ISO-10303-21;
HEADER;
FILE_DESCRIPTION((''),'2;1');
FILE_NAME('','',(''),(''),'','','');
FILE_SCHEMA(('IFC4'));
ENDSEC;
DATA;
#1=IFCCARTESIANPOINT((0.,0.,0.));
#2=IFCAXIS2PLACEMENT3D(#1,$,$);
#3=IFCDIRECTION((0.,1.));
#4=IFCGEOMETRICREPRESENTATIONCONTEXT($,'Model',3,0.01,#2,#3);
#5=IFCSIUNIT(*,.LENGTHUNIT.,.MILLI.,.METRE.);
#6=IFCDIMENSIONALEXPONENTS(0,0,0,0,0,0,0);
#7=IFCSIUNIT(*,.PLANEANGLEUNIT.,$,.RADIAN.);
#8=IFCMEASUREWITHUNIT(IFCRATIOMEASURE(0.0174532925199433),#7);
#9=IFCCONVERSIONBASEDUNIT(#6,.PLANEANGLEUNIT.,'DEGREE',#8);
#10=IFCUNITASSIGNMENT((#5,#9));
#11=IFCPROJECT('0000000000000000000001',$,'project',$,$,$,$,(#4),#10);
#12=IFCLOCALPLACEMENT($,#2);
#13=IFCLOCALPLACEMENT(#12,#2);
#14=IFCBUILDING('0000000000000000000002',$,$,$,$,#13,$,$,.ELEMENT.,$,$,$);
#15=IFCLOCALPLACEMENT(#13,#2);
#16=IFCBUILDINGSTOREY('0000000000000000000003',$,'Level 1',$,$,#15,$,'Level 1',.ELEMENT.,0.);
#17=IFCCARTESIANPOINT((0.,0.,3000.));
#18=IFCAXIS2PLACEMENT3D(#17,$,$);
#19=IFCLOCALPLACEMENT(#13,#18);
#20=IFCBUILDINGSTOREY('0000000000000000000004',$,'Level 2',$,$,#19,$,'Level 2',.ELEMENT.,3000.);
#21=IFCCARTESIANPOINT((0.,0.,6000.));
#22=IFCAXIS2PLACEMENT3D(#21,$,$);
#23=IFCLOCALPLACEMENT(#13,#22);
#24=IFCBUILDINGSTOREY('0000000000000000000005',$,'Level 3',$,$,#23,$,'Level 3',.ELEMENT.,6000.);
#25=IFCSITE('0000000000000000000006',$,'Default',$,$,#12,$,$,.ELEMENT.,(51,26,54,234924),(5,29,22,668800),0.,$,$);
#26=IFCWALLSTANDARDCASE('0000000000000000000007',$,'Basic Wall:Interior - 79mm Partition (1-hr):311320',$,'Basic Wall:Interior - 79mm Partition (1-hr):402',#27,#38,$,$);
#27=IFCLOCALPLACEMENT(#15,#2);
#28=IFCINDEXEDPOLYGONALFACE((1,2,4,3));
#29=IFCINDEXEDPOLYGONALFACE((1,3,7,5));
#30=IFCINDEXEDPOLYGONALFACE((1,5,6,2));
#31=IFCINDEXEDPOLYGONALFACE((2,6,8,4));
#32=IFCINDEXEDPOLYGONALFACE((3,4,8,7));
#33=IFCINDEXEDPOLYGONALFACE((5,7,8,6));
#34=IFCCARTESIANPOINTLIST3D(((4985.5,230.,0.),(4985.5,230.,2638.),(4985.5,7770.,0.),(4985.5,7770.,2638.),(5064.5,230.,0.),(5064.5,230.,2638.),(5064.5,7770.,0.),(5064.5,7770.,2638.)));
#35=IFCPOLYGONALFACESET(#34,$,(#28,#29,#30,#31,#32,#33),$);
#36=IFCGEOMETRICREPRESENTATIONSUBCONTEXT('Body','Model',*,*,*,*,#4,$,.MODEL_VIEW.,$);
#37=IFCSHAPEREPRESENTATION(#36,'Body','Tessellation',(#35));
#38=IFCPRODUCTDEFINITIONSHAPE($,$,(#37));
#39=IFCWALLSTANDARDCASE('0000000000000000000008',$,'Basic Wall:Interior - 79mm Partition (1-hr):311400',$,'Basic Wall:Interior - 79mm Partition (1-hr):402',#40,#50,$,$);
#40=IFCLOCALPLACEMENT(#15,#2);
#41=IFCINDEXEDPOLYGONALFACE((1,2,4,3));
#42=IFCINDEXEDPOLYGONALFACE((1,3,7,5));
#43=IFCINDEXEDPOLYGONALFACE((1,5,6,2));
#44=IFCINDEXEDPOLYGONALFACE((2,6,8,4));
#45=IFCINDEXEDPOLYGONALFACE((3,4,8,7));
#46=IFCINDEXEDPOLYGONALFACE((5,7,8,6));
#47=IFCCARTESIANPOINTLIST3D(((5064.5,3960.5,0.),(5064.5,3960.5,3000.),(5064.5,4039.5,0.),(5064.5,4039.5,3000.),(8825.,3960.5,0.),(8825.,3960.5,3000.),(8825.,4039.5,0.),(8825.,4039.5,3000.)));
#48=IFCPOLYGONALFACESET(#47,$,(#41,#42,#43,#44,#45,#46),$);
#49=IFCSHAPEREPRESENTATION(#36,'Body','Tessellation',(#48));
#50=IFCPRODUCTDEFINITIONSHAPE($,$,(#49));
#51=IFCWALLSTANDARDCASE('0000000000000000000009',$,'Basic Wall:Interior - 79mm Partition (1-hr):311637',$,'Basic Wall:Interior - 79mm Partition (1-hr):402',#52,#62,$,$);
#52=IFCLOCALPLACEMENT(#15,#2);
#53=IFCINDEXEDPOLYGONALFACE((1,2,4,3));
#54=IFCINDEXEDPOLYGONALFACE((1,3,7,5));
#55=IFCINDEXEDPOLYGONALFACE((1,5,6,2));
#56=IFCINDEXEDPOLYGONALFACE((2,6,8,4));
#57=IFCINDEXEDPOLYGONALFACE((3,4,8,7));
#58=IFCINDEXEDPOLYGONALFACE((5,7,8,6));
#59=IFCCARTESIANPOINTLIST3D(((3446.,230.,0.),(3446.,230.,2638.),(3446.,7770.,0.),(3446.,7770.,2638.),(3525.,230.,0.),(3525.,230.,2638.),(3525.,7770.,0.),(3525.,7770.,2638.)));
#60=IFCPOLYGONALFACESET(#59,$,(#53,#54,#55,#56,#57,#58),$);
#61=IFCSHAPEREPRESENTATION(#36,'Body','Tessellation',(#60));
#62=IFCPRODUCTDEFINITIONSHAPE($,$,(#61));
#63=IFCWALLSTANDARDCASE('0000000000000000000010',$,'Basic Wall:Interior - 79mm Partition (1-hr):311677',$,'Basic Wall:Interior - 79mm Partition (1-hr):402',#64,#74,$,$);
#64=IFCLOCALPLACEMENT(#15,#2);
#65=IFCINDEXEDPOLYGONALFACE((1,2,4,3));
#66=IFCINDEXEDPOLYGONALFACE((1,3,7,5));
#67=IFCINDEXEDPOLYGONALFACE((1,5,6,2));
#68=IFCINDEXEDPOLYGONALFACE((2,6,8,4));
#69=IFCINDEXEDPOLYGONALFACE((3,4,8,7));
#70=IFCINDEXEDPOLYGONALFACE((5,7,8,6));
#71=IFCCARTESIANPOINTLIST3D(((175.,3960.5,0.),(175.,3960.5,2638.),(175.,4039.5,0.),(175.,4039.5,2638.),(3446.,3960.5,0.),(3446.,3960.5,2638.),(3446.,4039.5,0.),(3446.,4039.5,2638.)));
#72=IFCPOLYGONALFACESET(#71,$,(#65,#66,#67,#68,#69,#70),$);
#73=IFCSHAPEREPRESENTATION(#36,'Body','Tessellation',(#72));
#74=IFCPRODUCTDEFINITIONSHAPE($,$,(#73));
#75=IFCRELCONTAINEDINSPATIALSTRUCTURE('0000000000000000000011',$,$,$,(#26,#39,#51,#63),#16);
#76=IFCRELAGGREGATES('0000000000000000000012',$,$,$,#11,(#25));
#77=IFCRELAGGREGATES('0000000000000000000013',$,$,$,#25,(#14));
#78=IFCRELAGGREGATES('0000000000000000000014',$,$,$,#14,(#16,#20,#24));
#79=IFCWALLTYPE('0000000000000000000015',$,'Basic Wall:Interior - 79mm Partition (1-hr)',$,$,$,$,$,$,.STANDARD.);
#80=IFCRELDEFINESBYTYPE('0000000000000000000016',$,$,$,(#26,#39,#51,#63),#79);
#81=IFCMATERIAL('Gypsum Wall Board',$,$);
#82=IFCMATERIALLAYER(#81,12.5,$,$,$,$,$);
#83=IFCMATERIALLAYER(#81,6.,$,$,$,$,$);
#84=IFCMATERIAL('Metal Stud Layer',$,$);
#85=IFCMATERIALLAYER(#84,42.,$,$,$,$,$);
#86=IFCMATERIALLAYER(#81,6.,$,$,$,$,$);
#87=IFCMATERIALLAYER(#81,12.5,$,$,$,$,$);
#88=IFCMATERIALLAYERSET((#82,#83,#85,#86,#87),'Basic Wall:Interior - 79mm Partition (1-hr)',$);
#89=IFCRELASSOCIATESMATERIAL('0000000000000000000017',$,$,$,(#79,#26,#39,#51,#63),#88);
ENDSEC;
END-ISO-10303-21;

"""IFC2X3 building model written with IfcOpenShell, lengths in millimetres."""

from ifc_helpers import new_model, entity, si_unit, converted_unit, direction, frame, frame_2d, origin, place, context, subcontext, project, spatial, polyline, rectangle, extrude, clip, bounded_halfspace, material, layer, layer_set, layer_usage, type_object, element, save


model = new_model("IFC2X3")

# Units and contexts
model_context = context("Model", 3, precision=0.01, world=origin(), true_north=direction((0.0, 1.0)))
body_context = subcontext(model_context, "Body", "Model", "MODEL_VIEW")
ifc_project = project(units=[si_unit("LENGTHUNIT", "METRE", prefix="MILLI"), converted_unit("PLANEANGLEUNIT", "DEGREE", entity("IfcRatioMeasure", 0.0174532925199433), si_unit("PLANEANGLEUNIT", "RADIAN"), dimensions=[0, 0, 0, 0, 0, 0, 0])], contexts=[model_context])

# Site, building, storey
site_placement = place(None, origin())
site = spatial("IfcSite", under=ifc_project, at=site_placement, Name="Default", CompositionType="ELEMENT", RefLatitude=(51, 26, 54, 234924), RefLongitude=(5, 29, 22, 668800), RefElevation=0.0)
building_placement = place(site_placement, origin())
building = spatial("IfcBuilding", under=site, at=building_placement, CompositionType="ELEMENT")
storey_1_placement = place(building_placement, origin())
storey_1 = spatial("IfcBuildingStorey", under=building, at=storey_1_placement, Name="Level 1", LongName="Level 1", CompositionType="ELEMENT", Elevation=0.0)

# Shared definitions
ifc_material_1 = material(Name="Metal Stud Layer")
ifc_material_2 = material(Name="Gypsum Wall Board")

# Shared definitions
storey_2_placement = place(building_placement, frame((0.0, 0.0, 3000.0)))
storey_2 = spatial("IfcBuildingStorey", under=building, at=storey_2_placement, Name="Level 2", LongName="Level 2", CompositionType="ELEMENT", Elevation=3000.0)

# Shared definitions
storey_3_placement = place(building_placement, frame((0.0, 0.0, 6000.0)))
storey_3 = spatial("IfcBuildingStorey", under=building, at=storey_3_placement, Name="Level 3", LongName="Level 3", CompositionType="ELEMENT", Elevation=6000.0)

# Walls
ifc_layer_1 = layer(ifc_material_2, 12.5)
ifc_layer_2 = layer(ifc_material_2, 6.0)
ifc_layer_3 = layer(ifc_material_1, 42.0)
ifc_layer_4 = layer(ifc_material_2, 6.0)
ifc_layer_5 = layer(ifc_material_2, 12.5)
ifc_layer_set_1 = layer_set([ifc_layer_1, ifc_layer_2, ifc_layer_3, ifc_layer_4, ifc_layer_5], Name="Basic Wall:Interior - 79mm Partition (1-hr)")
ifc_layer_usage_1 = layer_usage(ifc_layer_set_1, "AXIS2", "NEGATIVE", 39.5)
wall_type_1 = type_object("IfcWallType", Name="Basic Wall:Interior - 79mm Partition (1-hr)", PredefinedType="STANDARD", material=ifc_layer_set_1)
wall_1_placement = place(storey_1_placement, frame((5025.0, 7770.0, 0.0), z_axis=(0.0, 0.0, 1.0), x_axis=(0.0, -1.0, 0.0)))
element("IfcWallStandardCase", 1, at=wall_1_placement, inside=storey_1, type_object=wall_type_1, material=ifc_layer_usage_1, Name="Basic Wall:Interior - 79mm Partition (1-hr):311320", ObjectType="Basic Wall:Interior - 79mm Partition (1-hr):402", context=body_context, shape_type="Clipping", body=[
    clip(extrude(rectangle(XDim=7540.0, YDim=79.0, at=frame_2d((3770.0, 0.0), x_axis=(-1.0, 0.0))), origin(), (0.0, 0.0, 1.0), 2638.0), bounded_halfspace(frame((0.0, -39.5, 2638.0), z_axis=(0.0, 0.0, -1.0), x_axis=(1.0, 0.0, 0.0)), True, frame((0.0, -39.5, 2638.0)), polyline([(0.0, 0.0), (7540.0, 0.0), (7540.0, 29.5), (0.0, 29.5), (0.0, 0.0)]))),
])
ifc_layer_usage_2 = layer_usage(ifc_layer_set_1, "AXIS2", "NEGATIVE", 39.5)
wall_2_placement = place(storey_1_placement, frame((5064.5, 4000.0, 0.0)))
element("IfcWallStandardCase", 2, at=wall_2_placement, inside=storey_1, type_object=wall_type_1, material=ifc_layer_usage_2, Name="Basic Wall:Interior - 79mm Partition (1-hr):311400", ObjectType="Basic Wall:Interior - 79mm Partition (1-hr):402", context=body_context, shape_type="SweptSolid", body=[
    extrude(rectangle(XDim=3760.5, YDim=79.0, at=frame_2d((1880.2, 0.0), x_axis=(-1.0, 0.0))), origin(), (0.0, 0.0, 1.0), 3000.0),
])
ifc_layer_usage_3 = layer_usage(ifc_layer_set_1, "AXIS2", "NEGATIVE", 39.5)
wall_3_placement = place(storey_1_placement, frame((3485.5, 7770.0, 0.0), z_axis=(0.0, 0.0, 1.0), x_axis=(0.0, -1.0, 0.0)))
element("IfcWallStandardCase", 3, at=wall_3_placement, inside=storey_1, type_object=wall_type_1, material=ifc_layer_usage_3, Name="Basic Wall:Interior - 79mm Partition (1-hr):311637", ObjectType="Basic Wall:Interior - 79mm Partition (1-hr):402", context=body_context, shape_type="Clipping", body=[
    clip(extrude(rectangle(XDim=7540.0, YDim=79.0, at=frame_2d((3770.0, 0.0), x_axis=(-1.0, 0.0))), origin(), (0.0, 0.0, 1.0), 2638.0), bounded_halfspace(frame((0.0, -39.5, 2638.0), z_axis=(0.0, 0.0, -1.0), x_axis=(1.0, 0.0, 0.0)), True, frame((0.0, -39.5, 2638.0)), polyline([(0.0, 0.0), (3730.5, 0.0), (3809.5, 0.0), (7540.0, 0.0), (7540.0, 79.0), (0.0, 79.0), (0.0, 0.0)]))),
])
ifc_layer_usage_4 = layer_usage(ifc_layer_set_1, "AXIS2", "NEGATIVE", 39.5)
wall_4_placement = place(storey_1_placement, frame((3446.0, 4000.0, 0.0), z_axis=(0.0, 0.0, 1.0), x_axis=(-1.0, 0.0, 0.0)))
element("IfcWallStandardCase", 4, at=wall_4_placement, inside=storey_1, type_object=wall_type_1, material=ifc_layer_usage_4, Name="Basic Wall:Interior - 79mm Partition (1-hr):311677", ObjectType="Basic Wall:Interior - 79mm Partition (1-hr):402", context=body_context, shape_type="Clipping", body=[
    clip(extrude(rectangle(XDim=3271.0, YDim=79.0, at=frame_2d((1635.5, 0.0), x_axis=(-1.0, 0.0))), origin(), (0.0, 0.0, 1.0), 2638.0), bounded_halfspace(frame((0.0, -39.5, 2638.0), z_axis=(0.0, 0.0, -1.0), x_axis=(0.0, 1.0, 0.0)), True, frame((0.0, -39.5, 2638.0)), polyline([(0.0, 0.0), (3271.0, 0.0), (3271.0, 79.0), (0.0, 79.0), (0.0, 0.0)]))),
])

save(model, "model.ifc")
